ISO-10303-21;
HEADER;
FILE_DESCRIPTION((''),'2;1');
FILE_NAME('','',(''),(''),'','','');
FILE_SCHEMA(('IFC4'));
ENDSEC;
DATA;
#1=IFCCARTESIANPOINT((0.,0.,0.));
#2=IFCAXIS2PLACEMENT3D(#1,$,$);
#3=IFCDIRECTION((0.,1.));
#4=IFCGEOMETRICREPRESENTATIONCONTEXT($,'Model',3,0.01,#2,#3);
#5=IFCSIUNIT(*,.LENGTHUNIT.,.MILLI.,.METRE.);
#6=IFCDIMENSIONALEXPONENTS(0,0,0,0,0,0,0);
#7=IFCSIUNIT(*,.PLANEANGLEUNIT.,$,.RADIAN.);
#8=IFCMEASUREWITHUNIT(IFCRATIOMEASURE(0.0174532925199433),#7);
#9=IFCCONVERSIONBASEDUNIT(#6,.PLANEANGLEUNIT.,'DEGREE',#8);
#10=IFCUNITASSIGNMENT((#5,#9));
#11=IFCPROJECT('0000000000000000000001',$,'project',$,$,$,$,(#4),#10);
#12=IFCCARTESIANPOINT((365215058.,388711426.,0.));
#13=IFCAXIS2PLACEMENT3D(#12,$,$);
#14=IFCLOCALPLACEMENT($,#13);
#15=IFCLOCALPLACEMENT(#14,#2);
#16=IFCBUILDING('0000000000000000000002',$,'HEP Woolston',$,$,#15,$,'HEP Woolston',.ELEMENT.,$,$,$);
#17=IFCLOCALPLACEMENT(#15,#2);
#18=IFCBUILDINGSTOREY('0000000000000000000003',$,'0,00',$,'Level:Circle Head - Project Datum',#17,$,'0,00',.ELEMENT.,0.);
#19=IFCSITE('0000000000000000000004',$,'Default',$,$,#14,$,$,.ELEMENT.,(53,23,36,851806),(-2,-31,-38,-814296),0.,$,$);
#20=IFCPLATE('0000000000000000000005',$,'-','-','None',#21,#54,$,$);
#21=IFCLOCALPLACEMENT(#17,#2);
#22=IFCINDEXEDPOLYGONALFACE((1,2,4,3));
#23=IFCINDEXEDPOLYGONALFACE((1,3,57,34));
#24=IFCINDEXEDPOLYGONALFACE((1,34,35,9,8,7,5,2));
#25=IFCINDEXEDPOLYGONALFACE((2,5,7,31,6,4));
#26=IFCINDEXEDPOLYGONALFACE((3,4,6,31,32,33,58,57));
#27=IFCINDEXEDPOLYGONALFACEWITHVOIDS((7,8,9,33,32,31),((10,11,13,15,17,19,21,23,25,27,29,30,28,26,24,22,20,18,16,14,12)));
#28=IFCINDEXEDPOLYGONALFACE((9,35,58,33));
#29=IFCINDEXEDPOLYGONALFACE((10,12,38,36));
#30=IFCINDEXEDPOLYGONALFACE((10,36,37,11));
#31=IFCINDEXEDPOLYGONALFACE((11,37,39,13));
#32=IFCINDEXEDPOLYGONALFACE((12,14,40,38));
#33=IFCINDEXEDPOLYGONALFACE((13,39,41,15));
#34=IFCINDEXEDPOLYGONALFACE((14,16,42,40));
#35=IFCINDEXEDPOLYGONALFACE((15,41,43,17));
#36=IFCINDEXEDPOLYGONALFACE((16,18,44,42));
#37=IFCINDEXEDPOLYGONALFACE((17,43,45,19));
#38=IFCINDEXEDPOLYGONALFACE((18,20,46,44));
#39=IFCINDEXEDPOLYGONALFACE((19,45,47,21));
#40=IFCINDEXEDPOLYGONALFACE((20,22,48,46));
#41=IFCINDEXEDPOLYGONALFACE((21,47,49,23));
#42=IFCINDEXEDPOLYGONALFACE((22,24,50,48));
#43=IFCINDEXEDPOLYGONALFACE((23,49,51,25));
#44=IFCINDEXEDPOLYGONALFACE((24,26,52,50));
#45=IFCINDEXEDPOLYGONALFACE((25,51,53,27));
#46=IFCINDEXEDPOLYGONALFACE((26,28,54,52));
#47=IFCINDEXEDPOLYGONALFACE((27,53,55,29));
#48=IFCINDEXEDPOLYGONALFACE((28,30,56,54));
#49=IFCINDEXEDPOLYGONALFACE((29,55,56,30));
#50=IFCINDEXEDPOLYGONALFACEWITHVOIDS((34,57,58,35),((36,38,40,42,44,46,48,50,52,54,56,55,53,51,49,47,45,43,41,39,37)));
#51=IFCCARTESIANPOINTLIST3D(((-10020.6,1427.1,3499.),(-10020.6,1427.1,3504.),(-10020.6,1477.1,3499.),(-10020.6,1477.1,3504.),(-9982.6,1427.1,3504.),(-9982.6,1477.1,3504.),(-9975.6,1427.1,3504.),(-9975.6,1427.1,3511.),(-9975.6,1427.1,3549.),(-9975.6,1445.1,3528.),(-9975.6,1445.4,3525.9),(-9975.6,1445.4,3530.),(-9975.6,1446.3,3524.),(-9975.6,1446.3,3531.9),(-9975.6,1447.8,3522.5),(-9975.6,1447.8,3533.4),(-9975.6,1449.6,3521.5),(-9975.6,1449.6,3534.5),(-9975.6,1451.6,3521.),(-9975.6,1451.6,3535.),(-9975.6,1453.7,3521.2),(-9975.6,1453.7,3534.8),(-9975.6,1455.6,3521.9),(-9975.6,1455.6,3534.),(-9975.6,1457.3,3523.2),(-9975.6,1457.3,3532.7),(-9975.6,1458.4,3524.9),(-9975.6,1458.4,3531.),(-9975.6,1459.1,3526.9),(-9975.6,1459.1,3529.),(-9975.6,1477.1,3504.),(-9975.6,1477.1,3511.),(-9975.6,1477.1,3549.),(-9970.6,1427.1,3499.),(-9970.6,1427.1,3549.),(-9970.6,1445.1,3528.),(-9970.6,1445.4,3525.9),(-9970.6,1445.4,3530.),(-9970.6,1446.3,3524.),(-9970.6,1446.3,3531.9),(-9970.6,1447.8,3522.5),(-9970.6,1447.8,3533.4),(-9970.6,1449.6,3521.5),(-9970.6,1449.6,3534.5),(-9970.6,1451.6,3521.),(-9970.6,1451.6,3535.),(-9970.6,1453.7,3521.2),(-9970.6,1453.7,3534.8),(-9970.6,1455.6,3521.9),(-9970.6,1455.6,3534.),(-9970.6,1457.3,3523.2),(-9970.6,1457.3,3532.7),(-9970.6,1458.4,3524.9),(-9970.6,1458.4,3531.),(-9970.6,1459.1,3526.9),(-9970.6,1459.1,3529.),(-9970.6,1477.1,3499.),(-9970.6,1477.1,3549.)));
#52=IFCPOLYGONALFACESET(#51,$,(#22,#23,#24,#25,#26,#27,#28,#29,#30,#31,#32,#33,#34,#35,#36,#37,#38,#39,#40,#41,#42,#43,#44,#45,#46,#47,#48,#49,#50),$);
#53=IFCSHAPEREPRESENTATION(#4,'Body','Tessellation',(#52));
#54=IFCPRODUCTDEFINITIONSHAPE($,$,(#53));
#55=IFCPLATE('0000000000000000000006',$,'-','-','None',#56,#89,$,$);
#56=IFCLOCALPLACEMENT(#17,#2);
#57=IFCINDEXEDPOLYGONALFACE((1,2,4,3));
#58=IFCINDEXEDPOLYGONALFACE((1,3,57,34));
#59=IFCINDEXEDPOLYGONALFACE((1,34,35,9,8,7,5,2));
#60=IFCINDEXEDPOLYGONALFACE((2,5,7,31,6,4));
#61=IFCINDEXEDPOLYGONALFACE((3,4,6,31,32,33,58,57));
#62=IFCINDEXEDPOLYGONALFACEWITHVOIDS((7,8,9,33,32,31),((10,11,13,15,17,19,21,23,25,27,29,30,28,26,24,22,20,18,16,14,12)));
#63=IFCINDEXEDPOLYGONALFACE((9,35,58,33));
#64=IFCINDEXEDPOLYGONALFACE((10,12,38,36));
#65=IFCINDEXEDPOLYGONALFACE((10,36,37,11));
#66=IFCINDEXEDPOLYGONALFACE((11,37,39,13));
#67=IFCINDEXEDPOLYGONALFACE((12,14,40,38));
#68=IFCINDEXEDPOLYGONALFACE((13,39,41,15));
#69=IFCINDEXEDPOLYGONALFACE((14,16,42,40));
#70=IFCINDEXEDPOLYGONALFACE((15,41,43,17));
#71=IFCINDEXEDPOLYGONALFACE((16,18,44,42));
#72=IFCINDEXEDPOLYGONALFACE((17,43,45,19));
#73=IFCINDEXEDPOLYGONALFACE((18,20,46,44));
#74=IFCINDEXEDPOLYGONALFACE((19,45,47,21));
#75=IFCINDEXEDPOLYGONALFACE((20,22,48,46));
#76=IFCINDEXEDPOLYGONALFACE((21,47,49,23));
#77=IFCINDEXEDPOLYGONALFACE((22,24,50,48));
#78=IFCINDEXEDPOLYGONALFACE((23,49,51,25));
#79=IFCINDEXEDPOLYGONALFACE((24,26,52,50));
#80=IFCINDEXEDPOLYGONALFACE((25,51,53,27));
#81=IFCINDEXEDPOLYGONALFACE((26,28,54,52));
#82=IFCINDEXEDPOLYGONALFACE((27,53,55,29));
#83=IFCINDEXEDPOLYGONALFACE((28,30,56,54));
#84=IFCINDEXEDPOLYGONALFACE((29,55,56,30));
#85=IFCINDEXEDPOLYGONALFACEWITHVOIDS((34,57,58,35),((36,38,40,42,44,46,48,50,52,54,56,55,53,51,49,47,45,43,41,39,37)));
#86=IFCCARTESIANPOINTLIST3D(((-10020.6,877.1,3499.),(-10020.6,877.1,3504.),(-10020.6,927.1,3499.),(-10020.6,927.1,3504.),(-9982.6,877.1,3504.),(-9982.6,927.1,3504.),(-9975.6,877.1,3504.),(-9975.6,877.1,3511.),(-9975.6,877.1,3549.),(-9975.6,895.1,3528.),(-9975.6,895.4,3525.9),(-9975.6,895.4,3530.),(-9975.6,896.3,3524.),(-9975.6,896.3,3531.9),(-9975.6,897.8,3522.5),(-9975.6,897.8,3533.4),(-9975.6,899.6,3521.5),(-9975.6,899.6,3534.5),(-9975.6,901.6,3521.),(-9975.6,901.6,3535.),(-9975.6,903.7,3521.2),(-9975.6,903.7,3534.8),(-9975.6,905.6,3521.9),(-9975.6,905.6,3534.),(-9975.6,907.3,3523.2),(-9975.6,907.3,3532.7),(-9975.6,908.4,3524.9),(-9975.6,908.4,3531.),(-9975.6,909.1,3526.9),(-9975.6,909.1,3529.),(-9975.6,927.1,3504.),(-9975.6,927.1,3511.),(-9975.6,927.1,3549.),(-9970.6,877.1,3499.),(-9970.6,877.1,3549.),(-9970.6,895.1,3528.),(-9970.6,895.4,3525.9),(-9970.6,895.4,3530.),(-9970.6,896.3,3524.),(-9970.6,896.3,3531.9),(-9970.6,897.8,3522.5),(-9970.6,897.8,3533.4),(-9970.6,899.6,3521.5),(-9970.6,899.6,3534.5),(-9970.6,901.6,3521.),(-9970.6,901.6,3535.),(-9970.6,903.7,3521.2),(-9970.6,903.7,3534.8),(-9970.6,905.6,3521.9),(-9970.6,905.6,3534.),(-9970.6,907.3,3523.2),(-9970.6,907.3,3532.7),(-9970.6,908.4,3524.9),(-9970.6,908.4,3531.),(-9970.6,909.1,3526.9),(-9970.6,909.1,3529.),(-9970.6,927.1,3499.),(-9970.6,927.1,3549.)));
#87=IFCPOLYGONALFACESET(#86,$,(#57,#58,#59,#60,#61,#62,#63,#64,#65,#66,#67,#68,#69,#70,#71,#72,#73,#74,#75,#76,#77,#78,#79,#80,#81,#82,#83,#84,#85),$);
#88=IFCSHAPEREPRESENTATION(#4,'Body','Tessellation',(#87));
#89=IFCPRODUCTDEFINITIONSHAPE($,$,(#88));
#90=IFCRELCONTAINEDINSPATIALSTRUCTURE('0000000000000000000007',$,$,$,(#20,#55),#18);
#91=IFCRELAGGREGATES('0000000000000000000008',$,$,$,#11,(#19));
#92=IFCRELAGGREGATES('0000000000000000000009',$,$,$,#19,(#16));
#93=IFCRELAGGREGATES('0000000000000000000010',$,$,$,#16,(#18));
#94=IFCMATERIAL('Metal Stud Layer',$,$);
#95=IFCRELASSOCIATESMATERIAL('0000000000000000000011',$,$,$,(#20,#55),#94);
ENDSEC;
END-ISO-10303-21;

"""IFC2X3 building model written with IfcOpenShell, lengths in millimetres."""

from ifc_helpers import new_model, entity, si_unit, converted_unit, point, direction, frame, frame_2d, origin, origin_with_axes, origin_2d_with_axis, place, context, project, spatial, polyline, circle_curve, line_curve, trimmed, segment, composite_curve, circle, outline, extrude, material, element, save


model = new_model("IFC2X3")

# Units and contexts
model_context = context("Model", 3, precision=0.01, world=origin(), true_north=direction((0.0, 1.0)))
ifc_project = project(units=[si_unit("LENGTHUNIT", "METRE", prefix="MILLI"), converted_unit("PLANEANGLEUNIT", "DEGREE", entity("IfcRatioMeasure", 0.0174532925199433), si_unit("PLANEANGLEUNIT", "RADIAN"), dimensions=[0, 0, 0, 0, 0, 0, 0])], contexts=[model_context])

# Site, building, storey
site_placement = place(None, frame((365215058.0, 388711426.0, 0.0)))
site = spatial("IfcSite", under=ifc_project, at=site_placement, Name="Default", CompositionType="ELEMENT", RefLatitude=(53, 23, 36, 851806), RefLongitude=(-2, -31, -38, -814296), RefElevation=0.0)
building_placement = place(site_placement, origin())
building = spatial("IfcBuilding", under=site, at=building_placement, Name="HEP Woolston", LongName="HEP Woolston", CompositionType="ELEMENT")
storey_placement = place(building_placement, origin())
storey = spatial("IfcBuildingStorey", under=building, at=storey_placement, Name="0,00", ObjectType="Level:Circle Head - Project Datum", LongName="0,00", CompositionType="ELEMENT", Elevation=0.0)

# Plates, openings
ifc_material = material(Name="Metal Stud Layer")
plate_1_placement = place(storey_placement, frame((-9970.6, 1427.1, 3499.0), z_axis=(0.0, 1.0, 0.0), x_axis=(-1.0, 0.0, 0.0)))
plate_1 = element("IfcPlate", 1, at=plate_1_placement, inside=storey, material=ifc_material, Name="-", Description="-", ObjectType="None", context=model_context, shape_type="SweptSolid", body=[
    extrude(outline(polyline([(0.0, 0.0), (50.0, 0.0), (50.0, 5.0), (5.0, 5.0), (5.0, 50.0), (0.0, 50.0), (0.0, 0.0)])), origin_with_axes(), (0.0, 0.0, 1.0), 50.0),
])
opening_1_placement = place(plate_1_placement, frame((0.0, 0.0, 0.0), z_axis=(0.0, 0.0, 1.0), x_axis=(1.0, 0.0, 0.0)))
element("IfcOpeningElement", 2, at=opening_1_placement, cuts=plate_1, ObjectType="Opening", context=model_context, shape_type="SweptSolid", body=[
    extrude(outline(composite_curve([segment(trimmed(line_curve((50.0, 5.0), (1.0, 0.0), 3.532613), [point((50.0, 5.0))], [point((46.5, 5.0))], True, "CARTESIAN"), True, "CONTINUOUS"), segment(trimmed(circle_curve(frame_2d((46.5, 1.5), x_axis=(-1.0, 0.0)), 3.5), [point((46.5, 5.0))], [point((50.0, 1.5))], False, "CARTESIAN"), True, "CONTINUOUS"), segment(trimmed(line_curve((50.0, 1.5), (0.0, -1.0), 3.532613), [point((50.0, 1.5))], [point((50.0, 5.0))], True, "CARTESIAN"), True, "CONTINUOUS")], self_intersect="UNKNOWN")), origin(), (0.0, 0.0, 1.0), 50.0),
])
opening_2_placement = place(plate_1_placement, origin_with_axes())
element("IfcOpeningElement", 3, at=opening_2_placement, cuts=plate_1, ObjectType="Opening", context=model_context, shape_type="SweptSolid", body=[
    extrude(outline(composite_curve([segment(trimmed(line_curve((5.0, 5.0), (0.0, -1.0), 7.046301), [point((5.0, 5.0))], [point((5.0, 12.0))], False, "CARTESIAN"), True, "CONTINUOUS"), segment(trimmed(circle_curve(frame_2d((12.0, 12.0), x_axis=(1.0, 0.0)), 7.0), [point((5.0, 12.0))], [point((12.0, 5.0))], True, "CARTESIAN"), True, "CONTINUOUS"), segment(trimmed(line_curve((12.0, 5.0), (1.0, 0.0), 7.046301), [point((12.0, 5.0))], [point((5.0, 5.0))], False, "CARTESIAN"), True, "CONTINUOUS")], self_intersect="UNKNOWN")), origin(), (0.0, 0.0, 1.0), 50.0),
])
opening_3_placement = place(plate_1_placement, frame((0.0, 0.0, 0.0), z_axis=(0.0, 0.0, 1.0), x_axis=(1.0, 0.0, 0.0)))
element("IfcOpeningElement", 4, at=opening_3_placement, cuts=plate_1, ObjectType="Opening", context=model_context, shape_type="SweptSolid", body=[
    extrude(outline(composite_curve([segment(trimmed(line_curve((5.0, 50.0), (1.0, 0.0), 3.4874), [point((5.0, 50.0))], [point((1.5, 50.0))], True, "CARTESIAN"), True, "CONTINUOUS"), segment(trimmed(circle_curve(frame_2d((1.5, 46.5), x_axis=(-1.0, 0.0)), 3.5), [point((1.5, 50.0))], [point((5.0, 46.5))], False, "CARTESIAN"), True, "CONTINUOUS"), segment(trimmed(line_curve((5.0, 46.5), (0.0, -1.0), 3.4874), [point((5.0, 46.5))], [point((5.0, 50.0))], True, "CARTESIAN"), True, "CONTINUOUS")], self_intersect="UNKNOWN")), origin(), (0.0, 0.0, 1.0), 50.0),
])
opening_4_placement = place(plate_1_placement, frame((-0.5, 29.0, 25.0), z_axis=(1.0, 0.0, 0.0), x_axis=(0.0, 0.0, -1.0)))
element("IfcOpeningElement", 5, at=opening_4_placement, cuts=plate_1, ObjectType="Opening", context=model_context, shape_type="SweptSolid", body=[
    extrude(circle(Radius=7.0, at=origin_2d_with_axis()), origin(), (0.0, 0.0, 1.0), 6.0),
])
plate_2_placement = place(storey_placement, frame((-9970.6, 877.1, 3499.0), z_axis=(0.0, 1.0, 0.0), x_axis=(-1.0, 0.0, 0.0)))
plate_2 = element("IfcPlate", 6, at=plate_2_placement, inside=storey, material=ifc_material, Name="-", Description="-", ObjectType="None", context=model_context, shape_type="SweptSolid", body=[
    extrude(outline(polyline([(0.0, 0.0), (50.0, 0.0), (50.0, 5.0), (5.0, 5.0), (5.0, 50.0), (0.0, 50.0), (0.0, 0.0)])), origin_with_axes(), (0.0, 0.0, 1.0), 50.0),
])
opening_5_placement = place(plate_2_placement, frame((0.0, 0.0, 0.0), z_axis=(0.0, 0.0, 1.0), x_axis=(1.0, 0.0, 0.0)))
element("IfcOpeningElement", 7, at=opening_5_placement, cuts=plate_2, ObjectType="Opening", context=model_context, shape_type="SweptSolid", body=[
    extrude(outline(composite_curve([segment(trimmed(line_curve((50.0, 5.0), (1.0, 0.0), 3.532613), [point((50.0, 5.0))], [point((46.5, 5.0))], True, "CARTESIAN"), True, "CONTINUOUS"), segment(trimmed(circle_curve(frame_2d((46.5, 1.5), x_axis=(-1.0, 0.0)), 3.5), [point((46.5, 5.0))], [point((50.0, 1.5))], False, "CARTESIAN"), True, "CONTINUOUS"), segment(trimmed(line_curve((50.0, 1.5), (0.0, -1.0), 3.532613), [point((50.0, 1.5))], [point((50.0, 5.0))], True, "CARTESIAN"), True, "CONTINUOUS")], self_intersect="UNKNOWN")), origin(), (0.0, 0.0, 1.0), 50.0),
])
opening_6_placement = place(plate_2_placement, origin_with_axes())
element("IfcOpeningElement", 8, at=opening_6_placement, cuts=plate_2, ObjectType="Opening", context=model_context, shape_type="SweptSolid", body=[
    extrude(outline(composite_curve([segment(trimmed(line_curve((5.0, 5.0), (0.0, -1.0), 7.046301), [point((5.0, 5.0))], [point((5.0, 12.0))], False, "CARTESIAN"), True, "CONTINUOUS"), segment(trimmed(circle_curve(frame_2d((12.0, 12.0), x_axis=(1.0, 0.0)), 7.0), [point((5.0, 12.0))], [point((12.0, 5.0))], True, "CARTESIAN"), True, "CONTINUOUS"), segment(trimmed(line_curve((12.0, 5.0), (1.0, 0.0), 7.046301), [point((12.0, 5.0))], [point((5.0, 5.0))], False, "CARTESIAN"), True, "CONTINUOUS")], self_intersect="UNKNOWN")), origin(), (0.0, 0.0, 1.0), 50.0),
])
opening_7_placement = place(plate_2_placement, frame((0.0, 0.0, 0.0), z_axis=(0.0, 0.0, 1.0), x_axis=(1.0, 0.0, 0.0)))
element("IfcOpeningElement", 9, at=opening_7_placement, cuts=plate_2, ObjectType="Opening", context=model_context, shape_type="SweptSolid", body=[
    extrude(outline(composite_curve([segment(trimmed(line_curve((5.0, 50.0), (1.0, 0.0), 3.4874), [point((5.0, 50.0))], [point((1.5, 50.0))], True, "CARTESIAN"), True, "CONTINUOUS"), segment(trimmed(circle_curve(frame_2d((1.5, 46.5), x_axis=(-1.0, 0.0)), 3.5), [point((1.5, 50.0))], [point((5.0, 46.5))], False, "CARTESIAN"), True, "CONTINUOUS"), segment(trimmed(line_curve((5.0, 46.5), (0.0, -1.0), 3.4874), [point((5.0, 46.5))], [point((5.0, 50.0))], True, "CARTESIAN"), True, "CONTINUOUS")], self_intersect="UNKNOWN")), origin(), (0.0, 0.0, 1.0), 50.0),
])
opening_8_placement = place(plate_2_placement, frame((-0.5, 29.0, 25.0), z_axis=(1.0, 0.0, 0.0), x_axis=(0.0, 0.0, -1.0)))
element("IfcOpeningElement", 10, at=opening_8_placement, cuts=plate_2, ObjectType="Opening", context=model_context, shape_type="SweptSolid", body=[
    extrude(circle(Radius=7.0, at=origin_2d_with_axis()), origin(), (0.0, 0.0, 1.0), 6.0),
])

save(model, "model.ifc")
